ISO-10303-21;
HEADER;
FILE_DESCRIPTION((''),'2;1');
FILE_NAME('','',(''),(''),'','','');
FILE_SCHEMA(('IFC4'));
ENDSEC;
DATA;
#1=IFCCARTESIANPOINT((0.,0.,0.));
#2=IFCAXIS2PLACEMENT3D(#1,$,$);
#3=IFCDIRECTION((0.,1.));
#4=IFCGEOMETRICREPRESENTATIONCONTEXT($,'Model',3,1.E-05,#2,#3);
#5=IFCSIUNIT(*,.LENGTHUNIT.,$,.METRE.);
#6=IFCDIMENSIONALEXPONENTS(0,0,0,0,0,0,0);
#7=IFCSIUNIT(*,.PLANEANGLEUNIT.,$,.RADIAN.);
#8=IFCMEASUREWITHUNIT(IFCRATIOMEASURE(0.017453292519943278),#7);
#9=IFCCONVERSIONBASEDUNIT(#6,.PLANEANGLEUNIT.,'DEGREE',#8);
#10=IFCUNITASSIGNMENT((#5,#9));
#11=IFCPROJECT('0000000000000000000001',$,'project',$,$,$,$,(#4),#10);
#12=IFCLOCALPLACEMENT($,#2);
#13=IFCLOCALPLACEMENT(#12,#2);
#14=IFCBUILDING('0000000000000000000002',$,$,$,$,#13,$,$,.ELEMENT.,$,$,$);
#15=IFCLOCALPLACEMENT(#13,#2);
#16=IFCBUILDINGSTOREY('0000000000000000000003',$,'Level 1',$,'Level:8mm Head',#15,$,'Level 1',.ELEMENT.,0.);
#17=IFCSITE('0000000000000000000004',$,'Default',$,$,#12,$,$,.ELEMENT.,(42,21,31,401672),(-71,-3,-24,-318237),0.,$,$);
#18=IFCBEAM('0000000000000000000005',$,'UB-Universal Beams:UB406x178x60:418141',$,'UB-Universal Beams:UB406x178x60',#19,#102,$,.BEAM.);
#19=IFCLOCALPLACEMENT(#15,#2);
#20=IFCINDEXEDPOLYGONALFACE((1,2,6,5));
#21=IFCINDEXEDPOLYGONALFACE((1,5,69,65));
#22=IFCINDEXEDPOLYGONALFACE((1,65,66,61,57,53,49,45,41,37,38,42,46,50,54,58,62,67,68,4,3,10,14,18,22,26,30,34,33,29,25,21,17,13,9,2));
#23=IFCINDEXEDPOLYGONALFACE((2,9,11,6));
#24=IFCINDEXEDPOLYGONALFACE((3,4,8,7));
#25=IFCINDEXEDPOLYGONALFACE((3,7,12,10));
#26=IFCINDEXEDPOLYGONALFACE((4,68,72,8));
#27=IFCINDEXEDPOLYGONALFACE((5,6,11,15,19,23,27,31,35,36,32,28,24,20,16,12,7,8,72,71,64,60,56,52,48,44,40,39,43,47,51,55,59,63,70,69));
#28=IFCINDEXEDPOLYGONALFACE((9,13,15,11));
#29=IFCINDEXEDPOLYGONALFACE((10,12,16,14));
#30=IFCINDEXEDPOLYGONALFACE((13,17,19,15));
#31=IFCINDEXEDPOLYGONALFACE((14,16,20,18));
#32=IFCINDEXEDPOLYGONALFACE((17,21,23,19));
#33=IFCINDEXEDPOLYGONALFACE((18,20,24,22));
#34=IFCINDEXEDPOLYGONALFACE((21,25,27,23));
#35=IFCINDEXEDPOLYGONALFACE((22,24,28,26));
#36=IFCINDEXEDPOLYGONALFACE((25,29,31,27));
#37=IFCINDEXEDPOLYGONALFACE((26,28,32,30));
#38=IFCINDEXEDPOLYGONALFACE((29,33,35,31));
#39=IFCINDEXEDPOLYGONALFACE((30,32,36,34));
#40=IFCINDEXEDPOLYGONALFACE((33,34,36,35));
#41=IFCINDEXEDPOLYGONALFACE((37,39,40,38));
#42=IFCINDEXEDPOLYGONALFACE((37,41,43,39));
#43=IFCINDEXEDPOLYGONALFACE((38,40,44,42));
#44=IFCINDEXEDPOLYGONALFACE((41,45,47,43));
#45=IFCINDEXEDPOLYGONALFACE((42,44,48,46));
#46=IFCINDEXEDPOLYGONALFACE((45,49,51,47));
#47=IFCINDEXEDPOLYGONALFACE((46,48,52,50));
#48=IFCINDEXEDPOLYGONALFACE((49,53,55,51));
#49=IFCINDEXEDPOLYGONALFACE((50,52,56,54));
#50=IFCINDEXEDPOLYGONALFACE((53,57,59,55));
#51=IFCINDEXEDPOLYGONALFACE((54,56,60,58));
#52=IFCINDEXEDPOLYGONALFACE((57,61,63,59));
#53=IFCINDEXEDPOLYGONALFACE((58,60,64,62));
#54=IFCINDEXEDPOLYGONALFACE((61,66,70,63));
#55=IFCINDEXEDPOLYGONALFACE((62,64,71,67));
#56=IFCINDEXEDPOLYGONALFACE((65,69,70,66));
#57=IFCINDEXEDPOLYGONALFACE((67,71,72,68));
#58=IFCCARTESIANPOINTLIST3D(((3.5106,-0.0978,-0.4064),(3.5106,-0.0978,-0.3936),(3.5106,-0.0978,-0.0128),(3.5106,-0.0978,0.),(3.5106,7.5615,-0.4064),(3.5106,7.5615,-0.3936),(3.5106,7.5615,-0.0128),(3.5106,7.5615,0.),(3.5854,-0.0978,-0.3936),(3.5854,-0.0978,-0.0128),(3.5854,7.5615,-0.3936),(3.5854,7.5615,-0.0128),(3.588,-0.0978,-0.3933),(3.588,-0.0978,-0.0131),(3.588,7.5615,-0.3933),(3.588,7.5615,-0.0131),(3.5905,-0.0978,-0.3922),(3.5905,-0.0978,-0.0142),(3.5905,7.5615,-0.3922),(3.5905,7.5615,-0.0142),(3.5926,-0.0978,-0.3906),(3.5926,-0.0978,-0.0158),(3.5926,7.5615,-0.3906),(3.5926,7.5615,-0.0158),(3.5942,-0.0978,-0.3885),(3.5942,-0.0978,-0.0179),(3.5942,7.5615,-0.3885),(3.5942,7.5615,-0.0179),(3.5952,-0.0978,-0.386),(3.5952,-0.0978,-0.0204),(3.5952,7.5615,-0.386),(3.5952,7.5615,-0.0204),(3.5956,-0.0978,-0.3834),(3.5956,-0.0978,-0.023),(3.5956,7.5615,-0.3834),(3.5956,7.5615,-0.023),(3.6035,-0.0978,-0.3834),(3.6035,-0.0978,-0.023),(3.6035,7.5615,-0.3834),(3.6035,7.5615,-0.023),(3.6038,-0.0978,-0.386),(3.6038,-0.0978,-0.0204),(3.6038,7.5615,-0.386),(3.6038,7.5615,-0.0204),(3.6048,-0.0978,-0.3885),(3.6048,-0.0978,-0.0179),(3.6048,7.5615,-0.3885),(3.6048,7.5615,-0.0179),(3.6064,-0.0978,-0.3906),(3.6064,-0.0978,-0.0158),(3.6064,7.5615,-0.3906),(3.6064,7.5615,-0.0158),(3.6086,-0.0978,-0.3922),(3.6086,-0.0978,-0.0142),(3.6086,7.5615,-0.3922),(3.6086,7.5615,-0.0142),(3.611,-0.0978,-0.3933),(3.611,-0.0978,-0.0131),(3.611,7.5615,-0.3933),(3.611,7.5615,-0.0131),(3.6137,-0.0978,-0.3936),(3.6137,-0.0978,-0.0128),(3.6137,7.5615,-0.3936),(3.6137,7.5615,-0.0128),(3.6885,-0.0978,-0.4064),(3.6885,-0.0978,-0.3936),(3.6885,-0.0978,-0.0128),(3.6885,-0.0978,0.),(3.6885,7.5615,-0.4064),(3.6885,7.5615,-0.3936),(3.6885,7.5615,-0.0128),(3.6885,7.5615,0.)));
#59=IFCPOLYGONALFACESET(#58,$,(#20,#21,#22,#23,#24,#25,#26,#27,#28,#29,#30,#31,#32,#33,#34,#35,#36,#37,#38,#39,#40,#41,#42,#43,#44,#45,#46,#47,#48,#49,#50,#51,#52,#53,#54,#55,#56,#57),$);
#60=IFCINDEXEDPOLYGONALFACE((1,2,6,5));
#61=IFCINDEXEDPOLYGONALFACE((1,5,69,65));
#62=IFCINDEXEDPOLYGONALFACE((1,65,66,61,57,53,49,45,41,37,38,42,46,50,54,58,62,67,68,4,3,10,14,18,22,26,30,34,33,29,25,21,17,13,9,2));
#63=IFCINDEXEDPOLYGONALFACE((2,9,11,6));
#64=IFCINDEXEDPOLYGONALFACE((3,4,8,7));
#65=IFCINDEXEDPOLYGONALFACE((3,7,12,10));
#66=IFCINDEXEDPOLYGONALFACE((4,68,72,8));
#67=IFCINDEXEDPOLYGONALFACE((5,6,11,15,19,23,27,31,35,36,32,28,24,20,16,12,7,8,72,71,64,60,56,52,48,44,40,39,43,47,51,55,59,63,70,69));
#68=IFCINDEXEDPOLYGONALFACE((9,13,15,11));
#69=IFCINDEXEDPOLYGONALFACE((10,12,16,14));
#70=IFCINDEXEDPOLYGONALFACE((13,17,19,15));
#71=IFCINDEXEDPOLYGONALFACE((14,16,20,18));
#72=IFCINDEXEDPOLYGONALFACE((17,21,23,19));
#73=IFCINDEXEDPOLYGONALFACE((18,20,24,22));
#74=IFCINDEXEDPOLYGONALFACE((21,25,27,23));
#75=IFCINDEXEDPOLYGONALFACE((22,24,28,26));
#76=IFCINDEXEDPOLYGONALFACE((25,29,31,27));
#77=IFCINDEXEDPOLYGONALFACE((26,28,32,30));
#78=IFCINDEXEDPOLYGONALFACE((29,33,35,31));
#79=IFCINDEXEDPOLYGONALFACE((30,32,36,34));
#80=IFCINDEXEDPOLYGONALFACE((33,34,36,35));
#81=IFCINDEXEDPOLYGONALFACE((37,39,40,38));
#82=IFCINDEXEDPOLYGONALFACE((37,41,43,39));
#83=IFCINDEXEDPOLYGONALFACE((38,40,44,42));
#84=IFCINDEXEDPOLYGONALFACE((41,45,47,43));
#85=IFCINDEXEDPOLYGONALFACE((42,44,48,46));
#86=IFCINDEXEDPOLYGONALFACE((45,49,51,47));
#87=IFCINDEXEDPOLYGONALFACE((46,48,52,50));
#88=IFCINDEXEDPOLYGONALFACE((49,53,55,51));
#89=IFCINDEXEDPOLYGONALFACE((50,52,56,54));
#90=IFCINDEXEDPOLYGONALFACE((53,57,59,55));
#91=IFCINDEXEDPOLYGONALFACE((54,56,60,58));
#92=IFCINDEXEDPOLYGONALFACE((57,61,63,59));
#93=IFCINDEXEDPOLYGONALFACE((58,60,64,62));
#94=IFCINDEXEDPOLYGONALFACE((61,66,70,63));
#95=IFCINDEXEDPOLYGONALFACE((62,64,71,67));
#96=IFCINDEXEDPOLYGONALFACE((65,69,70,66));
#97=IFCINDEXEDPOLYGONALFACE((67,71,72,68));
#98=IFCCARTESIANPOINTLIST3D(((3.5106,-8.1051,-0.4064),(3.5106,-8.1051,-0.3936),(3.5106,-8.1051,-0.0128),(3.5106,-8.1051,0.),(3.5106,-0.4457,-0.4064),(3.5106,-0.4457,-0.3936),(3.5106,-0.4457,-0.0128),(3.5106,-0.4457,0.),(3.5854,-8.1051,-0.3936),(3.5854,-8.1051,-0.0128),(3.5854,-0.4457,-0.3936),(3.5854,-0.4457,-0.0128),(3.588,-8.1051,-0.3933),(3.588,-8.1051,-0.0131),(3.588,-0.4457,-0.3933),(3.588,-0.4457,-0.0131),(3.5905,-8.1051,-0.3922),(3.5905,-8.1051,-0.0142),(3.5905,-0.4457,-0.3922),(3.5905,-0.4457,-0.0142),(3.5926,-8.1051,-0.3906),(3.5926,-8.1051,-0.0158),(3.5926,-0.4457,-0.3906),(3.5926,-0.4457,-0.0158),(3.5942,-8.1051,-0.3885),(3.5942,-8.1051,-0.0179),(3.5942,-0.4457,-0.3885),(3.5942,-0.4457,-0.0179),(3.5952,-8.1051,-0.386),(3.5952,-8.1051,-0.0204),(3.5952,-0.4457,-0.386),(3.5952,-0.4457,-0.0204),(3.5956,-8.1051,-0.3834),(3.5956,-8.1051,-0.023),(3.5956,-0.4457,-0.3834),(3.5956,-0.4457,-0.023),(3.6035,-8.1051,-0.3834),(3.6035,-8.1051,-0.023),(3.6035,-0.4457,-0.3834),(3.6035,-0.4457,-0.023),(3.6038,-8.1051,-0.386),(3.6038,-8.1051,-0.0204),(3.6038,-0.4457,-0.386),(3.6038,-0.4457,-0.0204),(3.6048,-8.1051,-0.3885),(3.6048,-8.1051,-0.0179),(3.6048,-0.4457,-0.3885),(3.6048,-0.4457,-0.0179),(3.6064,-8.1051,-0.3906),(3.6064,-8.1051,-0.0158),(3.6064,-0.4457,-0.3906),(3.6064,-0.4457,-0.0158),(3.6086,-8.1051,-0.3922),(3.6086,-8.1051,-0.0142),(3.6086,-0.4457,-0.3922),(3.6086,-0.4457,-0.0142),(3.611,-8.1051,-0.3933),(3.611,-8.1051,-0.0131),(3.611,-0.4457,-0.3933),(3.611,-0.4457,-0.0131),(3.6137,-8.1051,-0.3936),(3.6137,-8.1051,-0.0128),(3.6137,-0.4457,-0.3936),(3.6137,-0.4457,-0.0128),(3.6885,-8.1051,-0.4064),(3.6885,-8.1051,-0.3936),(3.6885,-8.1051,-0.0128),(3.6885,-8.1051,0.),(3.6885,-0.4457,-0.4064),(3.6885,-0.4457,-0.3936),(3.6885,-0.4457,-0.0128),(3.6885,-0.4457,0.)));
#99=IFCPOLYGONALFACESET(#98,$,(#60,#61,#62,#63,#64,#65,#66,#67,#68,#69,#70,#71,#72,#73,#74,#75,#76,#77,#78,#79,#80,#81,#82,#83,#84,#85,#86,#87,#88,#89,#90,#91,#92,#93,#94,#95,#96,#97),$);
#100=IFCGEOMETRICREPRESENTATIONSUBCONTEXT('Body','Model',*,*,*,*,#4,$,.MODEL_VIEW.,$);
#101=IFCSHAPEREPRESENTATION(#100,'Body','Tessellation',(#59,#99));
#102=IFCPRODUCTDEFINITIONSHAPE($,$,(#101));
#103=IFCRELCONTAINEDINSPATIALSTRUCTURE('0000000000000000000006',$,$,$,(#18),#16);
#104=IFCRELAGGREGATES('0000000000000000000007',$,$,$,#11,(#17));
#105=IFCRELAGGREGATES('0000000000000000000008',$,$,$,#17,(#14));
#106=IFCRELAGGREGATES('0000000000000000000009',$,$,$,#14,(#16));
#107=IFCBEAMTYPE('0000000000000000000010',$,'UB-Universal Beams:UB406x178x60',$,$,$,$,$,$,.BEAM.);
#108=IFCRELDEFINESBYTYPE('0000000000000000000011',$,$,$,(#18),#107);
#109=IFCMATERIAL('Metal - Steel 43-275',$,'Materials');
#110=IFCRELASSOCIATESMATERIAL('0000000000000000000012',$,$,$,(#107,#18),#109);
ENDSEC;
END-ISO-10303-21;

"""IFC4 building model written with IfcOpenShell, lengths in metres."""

from ifc_helpers import new_model, entity, si_unit, converted_unit, direction, frame, origin, place, context, subcontext, project, spatial, line, arc, indexed_curve, outline, extrude, source, transform, mapped, material, type_object, type_shapes, element, save


model = new_model("IFC4")

# Units and contexts
model_context = context("Model", 3, precision=1e-05, world=origin(), true_north=direction((0.0, 1.0)))
body_context = subcontext(model_context, "Body", "Model", "MODEL_VIEW")
ifc_project = project(units=[si_unit("LENGTHUNIT", "METRE"), converted_unit("PLANEANGLEUNIT", "DEGREE", entity("IfcRatioMeasure", 0.017453292519943278), si_unit("PLANEANGLEUNIT", "RADIAN"), dimensions=[0, 0, 0, 0, 0, 0, 0])], contexts=[model_context])

# Site, building, storey
site_placement = place(None, origin())
site = spatial("IfcSite", under=ifc_project, at=site_placement, Name="Default", CompositionType="ELEMENT", RefLatitude=(42, 21, 31, 401672), RefLongitude=(-71, -3, -24, -318237), RefElevation=0.0)
building_placement = place(site_placement, origin())
building = spatial("IfcBuilding", under=site, at=building_placement, CompositionType="ELEMENT")
storey_placement = place(building_placement, origin())
storey = spatial("IfcBuildingStorey", under=building, at=storey_placement, Name="Level 1", ObjectType="Level:8mm Head", LongName="Level 1", CompositionType="ELEMENT", Elevation=0.0)

# Beam
ifc_material_1 = material(Name="Metal - Steel 43-275", Category="Materials")
beam_type_1 = type_object("IfcBeamType", Name="UB-Universal Beams:UB406x178x60", PredefinedType="BEAM", material=ifc_material_1)
shared_shape_1 = source(origin(), body_context, "Body", "SweptSolid", [
    extrude(outline(indexed_curve([(-0.0889, -0.2032), (0.089, -0.2032), (0.089, -0.1904), (0.0142, -0.1904), (0.0069, -0.1874), (0.004, -0.1802), (0.004, 0.1802), (0.0069, 0.1874), (0.0142, 0.1904), (0.0889, 0.1904), (0.0889, 0.2032), (-0.0889, 0.2032), (-0.0889, 0.1904), (-0.0141, 0.1904), (-0.0069, 0.1874), (-0.0039, 0.1802), (-0.0039, -0.1802), (-0.0069, -0.1874), (-0.0141, -0.1904), (-0.0889, -0.1904)], segments=[line(1, 2, 3, 4), arc(4, 5, 6), line(6, 7), arc(7, 8, 9), line(9, 10, 11, 12, 13, 14), arc(14, 15, 16), line(16, 17), arc(17, 18, 19), line(19, 20, 1)], self_intersect=False)), frame((3.5995, -0.0978, -0.2032), z_axis=(0.0, 1.0, 0.0), x_axis=(-1.0, 0.0, 0.0)), (0.0, 0.0, 1.0), 7.6594),
    extrude(outline(indexed_curve([(-0.089, -0.2032), (0.0889, -0.2032), (0.0889, -0.1904), (0.0141, -0.1904), (0.0069, -0.1874), (0.0039, -0.1802), (0.0039, 0.1802), (0.0069, 0.1874), (0.0141, 0.1904), (0.0889, 0.1904), (0.0889, 0.2032), (-0.089, 0.2032), (-0.089, 0.1904), (-0.0142, 0.1904), (-0.0069, 0.1874), (-0.004, 0.1802), (-0.004, -0.1802), (-0.0069, -0.1874), (-0.0142, -0.1904), (-0.089, -0.1904)], segments=[line(1, 2, 3, 4), arc(4, 5, 6), line(6, 7), arc(7, 8, 9), line(9, 10, 11, 12, 13, 14), arc(14, 15, 16), line(16, 17), arc(17, 18, 19), line(19, 20, 1)], self_intersect=False)), frame((3.5995, -8.1051, -0.2032), z_axis=(0.0, 1.0, 0.0), x_axis=(-1.0, 0.0, 0.0)), (0.0, 0.0, 1.0), 7.6594),
])
type_shapes(beam_type_1, [shared_shape_1])
beam_1_placement = place(storey_placement, origin())
element("IfcBeam", 1, at=beam_1_placement, inside=storey, type_object=beam_type_1, material=ifc_material_1, Name="UB-Universal Beams:UB406x178x60:418141", ObjectType="UB-Universal Beams:UB406x178x60", PredefinedType="BEAM", context=body_context, shape_type="MappedRepresentation", body=[
    mapped(shared_shape_1, transform((0.0, 0.0, 0.0), scale=1.0)),
])

save(model, "model.ifc")
